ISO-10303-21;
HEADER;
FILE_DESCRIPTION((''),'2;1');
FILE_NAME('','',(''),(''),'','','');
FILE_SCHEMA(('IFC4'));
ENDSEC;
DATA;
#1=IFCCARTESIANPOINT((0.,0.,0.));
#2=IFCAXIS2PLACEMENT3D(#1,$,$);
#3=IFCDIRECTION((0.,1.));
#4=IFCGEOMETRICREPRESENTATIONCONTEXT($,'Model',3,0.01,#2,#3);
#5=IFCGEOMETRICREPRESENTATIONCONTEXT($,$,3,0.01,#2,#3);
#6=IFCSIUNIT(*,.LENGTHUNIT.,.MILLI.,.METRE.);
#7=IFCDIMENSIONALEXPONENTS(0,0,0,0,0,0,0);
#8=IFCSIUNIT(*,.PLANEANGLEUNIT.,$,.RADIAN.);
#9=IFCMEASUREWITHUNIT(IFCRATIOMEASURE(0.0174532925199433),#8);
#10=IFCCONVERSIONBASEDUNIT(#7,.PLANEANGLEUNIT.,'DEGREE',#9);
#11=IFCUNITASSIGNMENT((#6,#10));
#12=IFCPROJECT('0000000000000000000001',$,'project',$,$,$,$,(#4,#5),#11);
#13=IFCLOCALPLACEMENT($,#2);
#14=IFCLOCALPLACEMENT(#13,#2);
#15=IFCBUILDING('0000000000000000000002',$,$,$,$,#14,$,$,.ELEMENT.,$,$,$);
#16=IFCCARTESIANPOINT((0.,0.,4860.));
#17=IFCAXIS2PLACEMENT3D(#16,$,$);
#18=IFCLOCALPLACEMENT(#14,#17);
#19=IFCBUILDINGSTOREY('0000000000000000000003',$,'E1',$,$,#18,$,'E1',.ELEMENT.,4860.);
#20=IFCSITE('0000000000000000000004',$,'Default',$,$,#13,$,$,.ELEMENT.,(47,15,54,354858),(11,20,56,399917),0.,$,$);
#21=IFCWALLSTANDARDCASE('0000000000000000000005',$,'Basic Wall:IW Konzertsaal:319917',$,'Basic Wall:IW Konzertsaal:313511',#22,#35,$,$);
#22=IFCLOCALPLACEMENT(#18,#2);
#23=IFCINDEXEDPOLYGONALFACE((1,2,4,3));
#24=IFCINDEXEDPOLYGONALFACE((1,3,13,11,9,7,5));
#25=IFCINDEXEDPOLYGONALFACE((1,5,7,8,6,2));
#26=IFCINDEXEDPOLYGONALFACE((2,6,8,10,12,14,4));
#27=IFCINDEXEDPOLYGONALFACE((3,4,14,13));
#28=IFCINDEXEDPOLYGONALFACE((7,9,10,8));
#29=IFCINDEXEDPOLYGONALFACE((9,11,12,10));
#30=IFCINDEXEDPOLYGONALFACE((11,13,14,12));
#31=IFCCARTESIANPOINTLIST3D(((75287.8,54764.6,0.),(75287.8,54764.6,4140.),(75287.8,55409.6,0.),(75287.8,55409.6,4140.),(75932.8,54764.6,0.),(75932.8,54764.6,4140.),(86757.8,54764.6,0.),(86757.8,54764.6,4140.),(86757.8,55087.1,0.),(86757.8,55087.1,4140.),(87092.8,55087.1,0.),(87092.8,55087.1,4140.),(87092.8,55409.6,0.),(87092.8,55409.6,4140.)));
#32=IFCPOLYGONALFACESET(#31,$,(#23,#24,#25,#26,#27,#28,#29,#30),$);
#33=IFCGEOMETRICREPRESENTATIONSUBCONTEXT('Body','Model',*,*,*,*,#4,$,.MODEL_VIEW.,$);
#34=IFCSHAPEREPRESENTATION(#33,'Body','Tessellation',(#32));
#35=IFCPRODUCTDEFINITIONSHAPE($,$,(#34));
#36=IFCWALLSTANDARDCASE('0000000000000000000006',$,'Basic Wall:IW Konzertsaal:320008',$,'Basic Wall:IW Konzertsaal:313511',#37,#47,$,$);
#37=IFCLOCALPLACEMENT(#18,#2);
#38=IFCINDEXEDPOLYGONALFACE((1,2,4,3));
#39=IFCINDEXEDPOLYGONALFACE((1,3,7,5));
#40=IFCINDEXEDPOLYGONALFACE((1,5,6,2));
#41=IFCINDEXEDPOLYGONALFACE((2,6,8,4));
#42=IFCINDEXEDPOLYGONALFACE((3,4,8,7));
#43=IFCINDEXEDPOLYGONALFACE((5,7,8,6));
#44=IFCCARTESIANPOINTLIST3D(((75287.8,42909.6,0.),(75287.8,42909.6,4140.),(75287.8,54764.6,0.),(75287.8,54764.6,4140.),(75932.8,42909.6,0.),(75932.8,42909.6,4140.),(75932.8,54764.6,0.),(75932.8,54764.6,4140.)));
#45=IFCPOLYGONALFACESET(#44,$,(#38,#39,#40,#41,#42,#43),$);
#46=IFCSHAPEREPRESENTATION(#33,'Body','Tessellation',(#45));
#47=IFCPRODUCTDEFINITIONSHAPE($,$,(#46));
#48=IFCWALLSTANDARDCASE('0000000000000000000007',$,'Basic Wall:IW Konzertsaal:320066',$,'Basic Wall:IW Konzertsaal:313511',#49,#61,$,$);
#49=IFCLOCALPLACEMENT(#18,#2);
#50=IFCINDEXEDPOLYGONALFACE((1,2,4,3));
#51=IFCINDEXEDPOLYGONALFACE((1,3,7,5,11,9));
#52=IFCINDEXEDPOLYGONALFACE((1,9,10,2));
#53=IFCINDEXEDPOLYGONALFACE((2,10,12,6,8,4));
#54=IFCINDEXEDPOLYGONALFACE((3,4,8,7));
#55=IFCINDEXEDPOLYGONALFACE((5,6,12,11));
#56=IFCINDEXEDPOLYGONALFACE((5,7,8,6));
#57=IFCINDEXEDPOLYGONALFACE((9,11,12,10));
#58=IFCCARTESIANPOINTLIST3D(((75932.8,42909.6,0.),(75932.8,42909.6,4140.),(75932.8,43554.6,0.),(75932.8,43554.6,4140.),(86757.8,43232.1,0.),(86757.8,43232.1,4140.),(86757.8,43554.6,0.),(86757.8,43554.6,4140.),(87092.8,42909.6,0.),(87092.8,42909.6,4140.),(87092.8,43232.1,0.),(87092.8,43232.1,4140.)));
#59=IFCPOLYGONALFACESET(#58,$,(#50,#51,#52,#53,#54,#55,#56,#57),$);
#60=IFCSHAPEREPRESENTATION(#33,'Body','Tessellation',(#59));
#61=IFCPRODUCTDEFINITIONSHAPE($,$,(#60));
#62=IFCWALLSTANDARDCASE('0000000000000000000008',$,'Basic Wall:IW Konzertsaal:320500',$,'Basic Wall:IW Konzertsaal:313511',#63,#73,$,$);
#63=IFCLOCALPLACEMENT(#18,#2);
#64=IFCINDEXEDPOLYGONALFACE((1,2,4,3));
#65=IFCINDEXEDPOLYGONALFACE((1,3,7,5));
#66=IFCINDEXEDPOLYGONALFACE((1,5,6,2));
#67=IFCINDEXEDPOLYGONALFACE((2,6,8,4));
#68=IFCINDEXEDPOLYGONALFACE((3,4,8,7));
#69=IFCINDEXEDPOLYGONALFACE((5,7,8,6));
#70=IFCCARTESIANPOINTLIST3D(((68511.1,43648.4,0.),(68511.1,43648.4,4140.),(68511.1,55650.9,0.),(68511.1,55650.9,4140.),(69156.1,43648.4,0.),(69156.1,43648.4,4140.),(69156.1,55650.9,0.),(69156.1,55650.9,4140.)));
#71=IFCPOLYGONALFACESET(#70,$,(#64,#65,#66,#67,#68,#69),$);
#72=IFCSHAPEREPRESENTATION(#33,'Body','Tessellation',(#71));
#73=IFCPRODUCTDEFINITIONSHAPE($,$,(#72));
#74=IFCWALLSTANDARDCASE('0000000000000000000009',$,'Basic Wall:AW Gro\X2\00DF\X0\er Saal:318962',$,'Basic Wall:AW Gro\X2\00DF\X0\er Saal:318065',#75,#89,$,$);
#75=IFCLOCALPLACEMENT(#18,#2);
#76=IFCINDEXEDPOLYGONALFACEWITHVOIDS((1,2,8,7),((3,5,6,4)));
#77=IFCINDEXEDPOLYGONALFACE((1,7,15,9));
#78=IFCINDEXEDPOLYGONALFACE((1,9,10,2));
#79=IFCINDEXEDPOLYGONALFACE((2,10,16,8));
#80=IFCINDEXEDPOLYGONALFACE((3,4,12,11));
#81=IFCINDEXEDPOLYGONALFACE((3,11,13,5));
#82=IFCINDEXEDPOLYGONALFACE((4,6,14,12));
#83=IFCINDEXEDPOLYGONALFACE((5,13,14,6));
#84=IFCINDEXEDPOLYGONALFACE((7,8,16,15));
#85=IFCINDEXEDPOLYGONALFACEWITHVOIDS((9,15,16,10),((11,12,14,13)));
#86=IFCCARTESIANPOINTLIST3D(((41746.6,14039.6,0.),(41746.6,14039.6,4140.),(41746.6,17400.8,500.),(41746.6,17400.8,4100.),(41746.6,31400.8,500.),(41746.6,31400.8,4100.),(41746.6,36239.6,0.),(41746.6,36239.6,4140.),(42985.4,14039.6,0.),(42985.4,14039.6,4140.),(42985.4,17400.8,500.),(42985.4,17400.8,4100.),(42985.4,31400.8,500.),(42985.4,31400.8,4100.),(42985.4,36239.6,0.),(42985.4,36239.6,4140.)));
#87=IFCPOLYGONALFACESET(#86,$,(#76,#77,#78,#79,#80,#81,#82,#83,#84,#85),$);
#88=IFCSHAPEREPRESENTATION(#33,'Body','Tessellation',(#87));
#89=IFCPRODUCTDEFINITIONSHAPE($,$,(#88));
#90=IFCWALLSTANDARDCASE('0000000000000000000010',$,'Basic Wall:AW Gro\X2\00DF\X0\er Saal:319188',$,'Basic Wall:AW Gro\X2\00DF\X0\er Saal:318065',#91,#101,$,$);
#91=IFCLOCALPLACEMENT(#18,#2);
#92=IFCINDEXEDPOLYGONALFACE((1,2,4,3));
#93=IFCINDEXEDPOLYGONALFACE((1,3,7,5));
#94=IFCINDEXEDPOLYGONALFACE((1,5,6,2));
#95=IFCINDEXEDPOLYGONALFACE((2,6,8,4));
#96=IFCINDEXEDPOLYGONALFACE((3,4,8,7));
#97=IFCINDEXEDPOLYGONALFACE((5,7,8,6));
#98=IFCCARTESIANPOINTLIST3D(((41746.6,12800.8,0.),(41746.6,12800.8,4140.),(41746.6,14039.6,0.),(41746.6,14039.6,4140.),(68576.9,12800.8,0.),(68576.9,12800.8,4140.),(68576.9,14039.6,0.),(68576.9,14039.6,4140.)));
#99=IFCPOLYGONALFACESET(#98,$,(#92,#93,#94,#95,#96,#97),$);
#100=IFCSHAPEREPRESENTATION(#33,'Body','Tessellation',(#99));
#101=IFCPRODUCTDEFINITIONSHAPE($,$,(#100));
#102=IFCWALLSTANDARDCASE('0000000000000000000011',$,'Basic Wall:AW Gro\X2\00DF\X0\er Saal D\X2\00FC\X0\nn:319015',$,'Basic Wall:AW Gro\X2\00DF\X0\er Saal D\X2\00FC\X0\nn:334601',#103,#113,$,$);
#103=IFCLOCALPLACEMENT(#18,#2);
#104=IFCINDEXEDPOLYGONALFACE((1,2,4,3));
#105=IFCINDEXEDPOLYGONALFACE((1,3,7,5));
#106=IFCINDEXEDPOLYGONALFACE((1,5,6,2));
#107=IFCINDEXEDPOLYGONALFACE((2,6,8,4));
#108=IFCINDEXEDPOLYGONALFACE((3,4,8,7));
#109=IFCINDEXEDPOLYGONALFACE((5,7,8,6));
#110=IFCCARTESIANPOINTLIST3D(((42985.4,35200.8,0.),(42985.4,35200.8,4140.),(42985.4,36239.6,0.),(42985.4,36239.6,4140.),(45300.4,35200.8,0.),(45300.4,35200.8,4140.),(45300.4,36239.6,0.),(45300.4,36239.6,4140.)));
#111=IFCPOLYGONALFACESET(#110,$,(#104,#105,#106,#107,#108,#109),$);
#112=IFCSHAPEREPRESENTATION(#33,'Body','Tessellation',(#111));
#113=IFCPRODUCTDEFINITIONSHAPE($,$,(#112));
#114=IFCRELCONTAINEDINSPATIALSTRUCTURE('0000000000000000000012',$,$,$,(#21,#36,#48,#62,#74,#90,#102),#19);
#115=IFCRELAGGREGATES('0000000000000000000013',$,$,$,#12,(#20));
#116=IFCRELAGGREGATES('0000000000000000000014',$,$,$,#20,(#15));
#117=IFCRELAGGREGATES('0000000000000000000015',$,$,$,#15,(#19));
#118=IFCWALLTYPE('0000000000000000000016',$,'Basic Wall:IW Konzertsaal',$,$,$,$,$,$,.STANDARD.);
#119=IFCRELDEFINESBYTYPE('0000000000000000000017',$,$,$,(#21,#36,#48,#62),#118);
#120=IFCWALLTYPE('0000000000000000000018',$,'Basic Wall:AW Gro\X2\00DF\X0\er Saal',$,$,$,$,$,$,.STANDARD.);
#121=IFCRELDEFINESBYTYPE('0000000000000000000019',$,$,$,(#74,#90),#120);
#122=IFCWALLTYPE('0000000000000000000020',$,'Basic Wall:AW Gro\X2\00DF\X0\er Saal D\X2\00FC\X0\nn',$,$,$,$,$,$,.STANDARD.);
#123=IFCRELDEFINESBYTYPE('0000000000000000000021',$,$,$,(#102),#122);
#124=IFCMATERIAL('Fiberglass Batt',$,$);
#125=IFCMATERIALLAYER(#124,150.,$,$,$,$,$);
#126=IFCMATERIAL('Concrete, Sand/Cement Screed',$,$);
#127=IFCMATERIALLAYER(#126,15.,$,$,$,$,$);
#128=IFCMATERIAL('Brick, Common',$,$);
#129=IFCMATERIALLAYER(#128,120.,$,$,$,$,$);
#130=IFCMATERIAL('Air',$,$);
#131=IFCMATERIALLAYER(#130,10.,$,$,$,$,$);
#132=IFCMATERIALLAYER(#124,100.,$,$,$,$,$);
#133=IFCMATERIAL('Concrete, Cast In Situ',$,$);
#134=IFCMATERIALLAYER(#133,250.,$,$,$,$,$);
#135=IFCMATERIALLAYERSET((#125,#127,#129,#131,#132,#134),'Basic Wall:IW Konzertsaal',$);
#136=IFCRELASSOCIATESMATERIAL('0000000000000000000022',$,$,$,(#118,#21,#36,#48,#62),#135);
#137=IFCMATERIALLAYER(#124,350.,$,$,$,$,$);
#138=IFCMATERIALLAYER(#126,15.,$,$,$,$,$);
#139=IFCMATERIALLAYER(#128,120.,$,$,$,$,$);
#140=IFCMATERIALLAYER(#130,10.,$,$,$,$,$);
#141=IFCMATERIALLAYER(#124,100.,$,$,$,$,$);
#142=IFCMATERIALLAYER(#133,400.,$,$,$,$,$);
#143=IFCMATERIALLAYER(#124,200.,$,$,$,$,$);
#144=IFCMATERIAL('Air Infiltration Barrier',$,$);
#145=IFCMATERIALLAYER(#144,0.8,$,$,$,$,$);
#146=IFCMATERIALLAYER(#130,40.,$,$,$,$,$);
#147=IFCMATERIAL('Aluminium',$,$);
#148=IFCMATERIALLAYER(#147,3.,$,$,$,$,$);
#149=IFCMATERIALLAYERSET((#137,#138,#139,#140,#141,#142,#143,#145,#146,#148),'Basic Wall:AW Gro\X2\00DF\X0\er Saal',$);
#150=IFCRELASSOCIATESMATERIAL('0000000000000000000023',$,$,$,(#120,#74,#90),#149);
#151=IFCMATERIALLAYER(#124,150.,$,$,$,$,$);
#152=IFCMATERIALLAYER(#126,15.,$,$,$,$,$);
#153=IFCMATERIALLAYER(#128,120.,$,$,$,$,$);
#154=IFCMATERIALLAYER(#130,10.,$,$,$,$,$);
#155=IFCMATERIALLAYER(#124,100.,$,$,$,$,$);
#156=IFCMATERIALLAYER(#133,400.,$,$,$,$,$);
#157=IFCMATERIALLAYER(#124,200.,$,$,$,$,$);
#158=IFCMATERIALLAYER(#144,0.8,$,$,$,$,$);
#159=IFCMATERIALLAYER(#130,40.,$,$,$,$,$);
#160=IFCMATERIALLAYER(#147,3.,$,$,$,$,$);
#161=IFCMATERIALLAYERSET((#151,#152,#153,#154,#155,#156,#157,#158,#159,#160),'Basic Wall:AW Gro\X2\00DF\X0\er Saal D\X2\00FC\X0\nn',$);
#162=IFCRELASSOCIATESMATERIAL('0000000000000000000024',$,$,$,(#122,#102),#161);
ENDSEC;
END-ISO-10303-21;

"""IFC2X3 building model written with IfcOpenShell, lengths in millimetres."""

from ifc_helpers import new_model, entity, si_unit, converted_unit, direction, frame, frame_2d, origin, place, context, subcontext, project, spatial, polyline, rectangle, outline, extrude, material, layer, layer_set, layer_usage, type_object, element, save


model = new_model("IFC2X3")

# Units and contexts
model_context = context("Model", 3, precision=0.01, world=origin(), true_north=direction((0.0, 1.0)))
context_of_model = context(None, 3, precision=0.01, world=origin(), true_north=direction((0.0, 1.0)))
body_context = subcontext(model_context, "Body", "Model", "MODEL_VIEW")
ifc_project = project(units=[si_unit("LENGTHUNIT", "METRE", prefix="MILLI"), converted_unit("PLANEANGLEUNIT", "DEGREE", entity("IfcRatioMeasure", 0.0174532925199433), si_unit("PLANEANGLEUNIT", "RADIAN"), dimensions=[0, 0, 0, 0, 0, 0, 0])], contexts=[model_context, context_of_model])

# Site, building, storey
site_placement = place(None, origin())
site = spatial("IfcSite", under=ifc_project, at=site_placement, Name="Default", CompositionType="ELEMENT", RefLatitude=(47, 15, 54, 354858), RefLongitude=(11, 20, 56, 399917), RefElevation=0.0)
building_placement = place(site_placement, origin())
building = spatial("IfcBuilding", under=site, at=building_placement, CompositionType="ELEMENT")
storey_placement = place(building_placement, frame((0.0, 0.0, 4860.0)))
storey = spatial("IfcBuildingStorey", under=building, at=storey_placement, Name="E1", LongName="E1", CompositionType="ELEMENT", Elevation=4860.0)

# Shared definitions
ifc_material_1 = material(Name="Concrete, Sand/Cement Screed")
ifc_material_2 = material(Name="Air Infiltration Barrier")
ifc_material_3 = material(Name="Fiberglass Batt")

# Shared definitions
ifc_material_4 = material(Name="Aluminium")

# Shared definitions
ifc_material_5 = material(Name="Concrete, Cast In Situ")

# Shared definitions
ifc_material_6 = material(Name="Air")

# Walls
ifc_material_7 = material(Name="Brick, Common")
ifc_layer_1 = layer(ifc_material_3, 150.0)
ifc_layer_2 = layer(ifc_material_1, 15.0)
ifc_layer_3 = layer(ifc_material_7, 120.0)
ifc_layer_4 = layer(ifc_material_6, 10.0)
ifc_layer_5 = layer(ifc_material_3, 100.0)
ifc_layer_6 = layer(ifc_material_5, 250.0)
ifc_layer_set_1 = layer_set([ifc_layer_1, ifc_layer_2, ifc_layer_3, ifc_layer_4, ifc_layer_5, ifc_layer_6], Name="Basic Wall:IW Konzertsaal")
wall_type_1 = type_object("IfcWallType", Name="Basic Wall:IW Konzertsaal", PredefinedType="STANDARD", material=ifc_layer_set_1)
ifc_layer_usage_1 = layer_usage(ifc_layer_set_1, "AXIS2", "NEGATIVE", 322.5)
wall_1_placement = place(storey_placement, frame((87092.8, 55087.1, 0.0), z_axis=(0.0, 0.0, 1.0), x_axis=(-1.0, 0.0, 0.0)))
element("IfcWallStandardCase", 1, at=wall_1_placement, inside=storey, type_object=wall_type_1, material=ifc_layer_usage_1, Name="Basic Wall:IW Konzertsaal:319917", ObjectType="Basic Wall:IW Konzertsaal:313511", context=body_context, shape_type="SweptSolid", body=[
    extrude(outline(polyline([(11805.0, -322.5), (11805.0, 322.5), (11160.0, 322.5), (335.0, 322.5), (335.0, 0.0), (0.0, 0.0), (0.0, -322.5), (11805.0, -322.5)])), origin(), (0.0, 0.0, 1.0), 4140.0),
])
ifc_layer_usage_2 = layer_usage(ifc_layer_set_1, "AXIS2", "NEGATIVE", 322.5)
wall_2_placement = place(storey_placement, frame((75610.3, 54764.6, 0.0), z_axis=(0.0, 0.0, 1.0), x_axis=(0.0, -1.0, 0.0)))
element("IfcWallStandardCase", 2, at=wall_2_placement, inside=storey, type_object=wall_type_1, material=ifc_layer_usage_2, Name="Basic Wall:IW Konzertsaal:320008", ObjectType="Basic Wall:IW Konzertsaal:313511", context=body_context, shape_type="SweptSolid", body=[
    extrude(rectangle(XDim=11855.0, YDim=645.0, at=frame_2d((5927.5, 0.0), x_axis=(-1.0, 0.0))), origin(), (0.0, 0.0, 1.0), 4140.0),
])
ifc_layer_usage_3 = layer_usage(ifc_layer_set_1, "AXIS2", "NEGATIVE", 322.5)
wall_3_placement = place(storey_placement, frame((75932.8, 43232.1, 0.0)))
element("IfcWallStandardCase", 3, at=wall_3_placement, inside=storey, type_object=wall_type_1, material=ifc_layer_usage_3, Name="Basic Wall:IW Konzertsaal:320066", ObjectType="Basic Wall:IW Konzertsaal:313511", context=body_context, shape_type="SweptSolid", body=[
    extrude(outline(polyline([(11160.0, -322.5), (11160.0, 0.0), (10825.0, 0.0), (10825.0, 322.5), (0.0, 322.5), (0.0, -322.5), (11160.0, -322.5)])), origin(), (0.0, 0.0, 1.0), 4140.0),
])
ifc_layer_usage_4 = layer_usage(ifc_layer_set_1, "AXIS2", "NEGATIVE", 322.5)
wall_4_placement = place(storey_placement, frame((68833.6, 43648.4, 0.0), z_axis=(0.0, 0.0, 1.0), x_axis=(0.0, 1.0, 0.0)))
element("IfcWallStandardCase", 4, at=wall_4_placement, inside=storey, type_object=wall_type_1, material=ifc_layer_usage_4, Name="Basic Wall:IW Konzertsaal:320500", ObjectType="Basic Wall:IW Konzertsaal:313511", context=body_context, shape_type="SweptSolid", body=[
    extrude(rectangle(XDim=12002.4, YDim=645.0, at=frame_2d((6001.2, 0.0), x_axis=(-1.0, 0.0))), origin(), (0.0, 0.0, 1.0), 4140.0),
])

# Wall, opening
ifc_layer_7 = layer(ifc_material_3, 350.0)
ifc_layer_8 = layer(ifc_material_1, 15.0)
ifc_layer_9 = layer(ifc_material_7, 120.0)
ifc_layer_10 = layer(ifc_material_6, 10.0)
ifc_layer_11 = layer(ifc_material_3, 100.0)
ifc_layer_12 = layer(ifc_material_5, 400.0)
ifc_layer_13 = layer(ifc_material_3, 200.0)
ifc_layer_14 = layer(ifc_material_2, 0.8)
ifc_layer_15 = layer(ifc_material_6, 40.0)
ifc_layer_16 = layer(ifc_material_4, 3.0)
ifc_layer_set_2 = layer_set([ifc_layer_7, ifc_layer_8, ifc_layer_9, ifc_layer_10, ifc_layer_11, ifc_layer_12, ifc_layer_13, ifc_layer_14, ifc_layer_15, ifc_layer_16], Name="Basic Wall:AW Großer Saal")
ifc_layer_usage_5 = layer_usage(ifc_layer_set_2, "AXIS2", "POSITIVE", -619.4)
wall_type_2 = type_object("IfcWallType", Name="Basic Wall:AW Großer Saal", PredefinedType="STANDARD", material=ifc_layer_set_2)
wall_5_placement = place(storey_placement, frame((42366.0, 14039.6, 0.0), z_axis=(0.0, 0.0, 1.0), x_axis=(0.0, 1.0, 0.0)))
wall_5 = element("IfcWallStandardCase", 5, at=wall_5_placement, inside=storey, type_object=wall_type_2, material=ifc_layer_usage_5, Name="Basic Wall:AW Großer Saal:318962", ObjectType="Basic Wall:AW Großer Saal:318065", context=body_context, shape_type="SweptSolid", body=[
    extrude(rectangle(XDim=22200.0, YDim=1238.8, at=frame_2d((11100.0, 0.0), x_axis=(-1.0, 0.0))), origin(), (0.0, 0.0, 1.0), 4140.0),
])
opening_1_placement = place(wall_5_placement, frame((3361.2, -619.4, 500.0)))
element("IfcOpeningElement", 6, at=opening_1_placement, cuts=wall_5, ObjectType="Opening", context=body_context, shape_type="SweptSolid", body=[
    extrude(rectangle(XDim=3600.0, YDim=14000.0, at=frame_2d((1800.0, 7000.0), x_axis=(-1.0, 0.0))), frame((0.0, 0.0, 0.0), z_axis=(0.0, 1.0, 0.0), x_axis=(0.0, 0.0, 1.0)), (0.0, 0.0, 1.0), 1238.8),
])

# Walls
ifc_layer_usage_6 = layer_usage(ifc_layer_set_2, "AXIS2", "POSITIVE", -619.4)
wall_6_placement = place(storey_placement, frame((68576.9, 13420.2, 0.0), z_axis=(0.0, 0.0, 1.0), x_axis=(-1.0, 0.0, 0.0)))
element("IfcWallStandardCase", 7, at=wall_6_placement, inside=storey, type_object=wall_type_2, material=ifc_layer_usage_6, Name="Basic Wall:AW Großer Saal:319188", ObjectType="Basic Wall:AW Großer Saal:318065", context=body_context, shape_type="SweptSolid", body=[
    extrude(rectangle(XDim=26830.3, YDim=1238.8, at=frame_2d((13415.2, 0.0), x_axis=(-1.0, 0.0))), origin(), (0.0, 0.0, 1.0), 4140.0),
])
ifc_layer_17 = layer(ifc_material_3, 150.0)
ifc_layer_18 = layer(ifc_material_1, 15.0)
ifc_layer_19 = layer(ifc_material_7, 120.0)
ifc_layer_20 = layer(ifc_material_6, 10.0)
ifc_layer_21 = layer(ifc_material_3, 100.0)
ifc_layer_22 = layer(ifc_material_5, 400.0)
ifc_layer_23 = layer(ifc_material_3, 200.0)
ifc_layer_24 = layer(ifc_material_2, 0.8)
ifc_layer_25 = layer(ifc_material_6, 40.0)
ifc_layer_26 = layer(ifc_material_4, 3.0)
ifc_layer_set_3 = layer_set([ifc_layer_17, ifc_layer_18, ifc_layer_19, ifc_layer_20, ifc_layer_21, ifc_layer_22, ifc_layer_23, ifc_layer_24, ifc_layer_25, ifc_layer_26], Name="Basic Wall:AW Großer Saal Dünn")
ifc_layer_usage_7 = layer_usage(ifc_layer_set_3, "AXIS2", "POSITIVE", -519.4)
wall_type_3 = type_object("IfcWallType", Name="Basic Wall:AW Großer Saal Dünn", PredefinedType="STANDARD", material=ifc_layer_set_3)
wall_7_placement = place(storey_placement, frame((42985.4, 35720.2, 0.0)))
element("IfcWallStandardCase", 8, at=wall_7_placement, inside=storey, type_object=wall_type_3, material=ifc_layer_usage_7, Name="Basic Wall:AW Großer Saal Dünn:319015", ObjectType="Basic Wall:AW Großer Saal Dünn:334601", context=body_context, shape_type="SweptSolid", body=[
    extrude(rectangle(XDim=2315.0, YDim=1038.8, at=frame_2d((1157.5, 0.0), x_axis=(-1.0, 0.0))), origin(), (0.0, 0.0, 1.0), 4140.0),
])

save(model, "model.ifc")
